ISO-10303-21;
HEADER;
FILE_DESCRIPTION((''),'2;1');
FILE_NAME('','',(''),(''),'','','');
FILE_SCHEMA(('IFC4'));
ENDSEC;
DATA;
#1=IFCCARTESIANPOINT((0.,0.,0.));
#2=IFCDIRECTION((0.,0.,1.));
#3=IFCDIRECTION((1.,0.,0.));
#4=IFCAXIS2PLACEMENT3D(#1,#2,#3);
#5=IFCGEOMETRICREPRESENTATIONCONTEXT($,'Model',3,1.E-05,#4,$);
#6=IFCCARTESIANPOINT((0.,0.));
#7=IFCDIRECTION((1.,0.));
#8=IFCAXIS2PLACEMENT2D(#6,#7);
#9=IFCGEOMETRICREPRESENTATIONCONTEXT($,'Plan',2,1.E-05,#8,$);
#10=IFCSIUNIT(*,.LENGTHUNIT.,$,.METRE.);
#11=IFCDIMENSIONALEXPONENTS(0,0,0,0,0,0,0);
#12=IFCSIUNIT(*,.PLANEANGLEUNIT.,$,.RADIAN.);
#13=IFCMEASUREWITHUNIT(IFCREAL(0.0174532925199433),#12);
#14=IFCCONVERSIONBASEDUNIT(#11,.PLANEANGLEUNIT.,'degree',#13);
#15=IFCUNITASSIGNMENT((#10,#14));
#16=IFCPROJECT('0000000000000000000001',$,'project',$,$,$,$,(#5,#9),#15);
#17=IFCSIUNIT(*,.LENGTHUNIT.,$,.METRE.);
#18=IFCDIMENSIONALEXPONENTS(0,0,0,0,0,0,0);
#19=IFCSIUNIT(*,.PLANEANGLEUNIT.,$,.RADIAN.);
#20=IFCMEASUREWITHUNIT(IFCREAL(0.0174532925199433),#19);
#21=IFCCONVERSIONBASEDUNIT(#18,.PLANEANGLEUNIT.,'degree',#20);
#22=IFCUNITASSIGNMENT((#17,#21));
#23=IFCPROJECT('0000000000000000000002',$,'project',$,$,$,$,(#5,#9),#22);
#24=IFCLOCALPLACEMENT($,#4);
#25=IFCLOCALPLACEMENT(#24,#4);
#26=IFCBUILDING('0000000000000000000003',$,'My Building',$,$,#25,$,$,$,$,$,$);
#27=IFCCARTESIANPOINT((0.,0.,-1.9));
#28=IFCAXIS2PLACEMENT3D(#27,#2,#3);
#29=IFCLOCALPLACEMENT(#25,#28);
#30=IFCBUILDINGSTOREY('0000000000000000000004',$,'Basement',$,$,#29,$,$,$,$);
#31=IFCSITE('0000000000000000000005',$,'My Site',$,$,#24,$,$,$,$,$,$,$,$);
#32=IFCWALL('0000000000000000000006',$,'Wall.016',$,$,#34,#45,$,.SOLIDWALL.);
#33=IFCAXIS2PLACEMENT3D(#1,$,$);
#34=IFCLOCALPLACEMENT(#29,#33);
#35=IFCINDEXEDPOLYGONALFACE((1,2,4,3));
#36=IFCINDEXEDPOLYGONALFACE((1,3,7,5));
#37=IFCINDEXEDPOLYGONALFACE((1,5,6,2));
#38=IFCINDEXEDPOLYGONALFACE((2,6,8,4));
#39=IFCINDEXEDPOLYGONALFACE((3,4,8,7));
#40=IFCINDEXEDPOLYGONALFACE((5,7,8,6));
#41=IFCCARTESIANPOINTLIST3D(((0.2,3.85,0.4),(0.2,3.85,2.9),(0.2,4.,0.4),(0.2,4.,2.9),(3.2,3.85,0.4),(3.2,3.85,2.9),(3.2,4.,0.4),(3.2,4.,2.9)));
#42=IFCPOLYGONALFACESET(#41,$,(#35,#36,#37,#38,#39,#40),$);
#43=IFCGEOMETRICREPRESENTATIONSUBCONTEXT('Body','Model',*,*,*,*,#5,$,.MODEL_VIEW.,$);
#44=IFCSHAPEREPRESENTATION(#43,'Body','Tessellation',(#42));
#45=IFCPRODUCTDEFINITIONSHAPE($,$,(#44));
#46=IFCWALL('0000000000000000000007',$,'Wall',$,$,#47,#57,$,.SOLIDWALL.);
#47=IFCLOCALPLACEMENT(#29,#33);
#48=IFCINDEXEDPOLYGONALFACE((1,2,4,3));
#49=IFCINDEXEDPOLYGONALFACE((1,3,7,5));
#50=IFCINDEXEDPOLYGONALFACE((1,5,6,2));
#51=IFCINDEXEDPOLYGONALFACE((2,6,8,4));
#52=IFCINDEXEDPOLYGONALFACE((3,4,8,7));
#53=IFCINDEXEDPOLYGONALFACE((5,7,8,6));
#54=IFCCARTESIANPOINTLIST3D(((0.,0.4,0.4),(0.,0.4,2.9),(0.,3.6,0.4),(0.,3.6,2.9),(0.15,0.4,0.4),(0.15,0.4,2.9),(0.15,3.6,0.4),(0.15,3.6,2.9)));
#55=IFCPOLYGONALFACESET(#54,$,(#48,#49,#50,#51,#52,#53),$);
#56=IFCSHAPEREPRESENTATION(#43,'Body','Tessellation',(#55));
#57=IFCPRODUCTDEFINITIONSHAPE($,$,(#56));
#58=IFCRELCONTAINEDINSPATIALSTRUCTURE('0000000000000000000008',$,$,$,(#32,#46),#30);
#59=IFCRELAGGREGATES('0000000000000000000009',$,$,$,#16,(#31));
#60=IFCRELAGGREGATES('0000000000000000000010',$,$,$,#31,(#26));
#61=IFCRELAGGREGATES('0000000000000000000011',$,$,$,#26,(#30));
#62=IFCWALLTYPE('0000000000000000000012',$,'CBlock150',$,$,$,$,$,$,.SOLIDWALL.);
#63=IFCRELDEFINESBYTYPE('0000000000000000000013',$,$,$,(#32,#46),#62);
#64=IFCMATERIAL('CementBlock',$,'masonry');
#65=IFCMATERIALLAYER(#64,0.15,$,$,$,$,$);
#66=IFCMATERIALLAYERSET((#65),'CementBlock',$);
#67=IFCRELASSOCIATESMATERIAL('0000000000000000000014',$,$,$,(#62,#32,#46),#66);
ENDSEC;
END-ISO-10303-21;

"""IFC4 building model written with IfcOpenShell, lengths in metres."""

from ifc_helpers import new_model, entity, si_unit, converted_unit, frame, origin_with_axes, origin_2d_with_axis, place, context, subcontext, project, spatial, indexed_curve, outline, extrude, material, layer, layer_set, layer_usage, type_object, element, save


model = new_model("IFC4")

# Units and contexts
model_context = context("Model", 3, precision=1e-05, world=origin_with_axes())
plan_context = context("Plan", 2, precision=1e-05, world=origin_2d_with_axis())
body_context = subcontext(model_context, "Body", "Model", "MODEL_VIEW")
ifc_project_1 = project(units=[si_unit("LENGTHUNIT", "METRE"), converted_unit("PLANEANGLEUNIT", "degree", entity("IfcReal", 0.0174532925199433), si_unit("PLANEANGLEUNIT", "RADIAN"), dimensions=[0, 0, 0, 0, 0, 0, 0])], contexts=[model_context, plan_context])
ifc_project_2 = project(units=[si_unit("LENGTHUNIT", "METRE"), converted_unit("PLANEANGLEUNIT", "degree", entity("IfcReal", 0.0174532925199433), si_unit("PLANEANGLEUNIT", "RADIAN"), dimensions=[0, 0, 0, 0, 0, 0, 0])], contexts=[model_context, plan_context])

# Site, building, storey
site_placement = place(None, origin_with_axes())
site = spatial("IfcSite", under=ifc_project_1, at=site_placement, Name="My Site")
building_placement = place(site_placement, origin_with_axes())
building = spatial("IfcBuilding", under=site, at=building_placement, Name="My Building")
storey_placement = place(building_placement, frame((0.0, 0.0, -1.9), z_axis=(0.0, 0.0, 1.0), x_axis=(1.0, 0.0, 0.0)))
storey = spatial("IfcBuildingStorey", under=building, at=storey_placement, Name="Basement")

# Walls
ifc_material_1 = material(Name="CementBlock", Category="masonry")
ifc_layer_1 = layer(ifc_material_1, 0.15)
ifc_layer_set_1 = layer_set([ifc_layer_1], Name="CementBlock")
wall_type = type_object("IfcWallType", Name="CBlock150", PredefinedType="SOLIDWALL", material=ifc_layer_set_1)
ifc_layer_usage_1 = layer_usage(ifc_layer_set_1, "AXIS2", "POSITIVE", 0.0)
wall_1_placement = place(storey_placement, frame((3.2, 4.0, 0.4), z_axis=(0.0, 0.0, 1.0), x_axis=(-1.0, 0.0, 0.0)))
element("IfcWall", 1, at=wall_1_placement, inside=storey, type_object=wall_type, material=ifc_layer_usage_1, Name="Wall.016", PredefinedType="SOLIDWALL", context=body_context, shape_type="SweptSolid", body=[
    extrude(outline(indexed_curve([(0.0, 0.0), (0.0, 0.15), (3.0, 0.15), (3.0, 0.0), (0.0, 0.0)], self_intersect=False)), origin_with_axes(), (0.0, 0.0, 1.0), 2.5),
])
ifc_layer_usage_2 = layer_usage(ifc_layer_set_1, "AXIS2", "POSITIVE", 0.0)
wall_2_placement = place(storey_placement, frame((0.0, 3.6, 0.4), z_axis=(0.0, 0.0, 1.0), x_axis=(0.0, -1.0, 0.0)))
element("IfcWall", 2, at=wall_2_placement, inside=storey, type_object=wall_type, material=ifc_layer_usage_2, Name="Wall", PredefinedType="SOLIDWALL", context=body_context, shape_type="SweptSolid", body=[
    extrude(outline(indexed_curve([(0.0, 0.0), (0.0, 0.15), (3.2, 0.15), (3.2, 0.0), (0.0, 0.0)], self_intersect=False)), origin_with_axes(), (0.0, 0.0, 1.0), 2.5),
])

save(model, "model.ifc")
